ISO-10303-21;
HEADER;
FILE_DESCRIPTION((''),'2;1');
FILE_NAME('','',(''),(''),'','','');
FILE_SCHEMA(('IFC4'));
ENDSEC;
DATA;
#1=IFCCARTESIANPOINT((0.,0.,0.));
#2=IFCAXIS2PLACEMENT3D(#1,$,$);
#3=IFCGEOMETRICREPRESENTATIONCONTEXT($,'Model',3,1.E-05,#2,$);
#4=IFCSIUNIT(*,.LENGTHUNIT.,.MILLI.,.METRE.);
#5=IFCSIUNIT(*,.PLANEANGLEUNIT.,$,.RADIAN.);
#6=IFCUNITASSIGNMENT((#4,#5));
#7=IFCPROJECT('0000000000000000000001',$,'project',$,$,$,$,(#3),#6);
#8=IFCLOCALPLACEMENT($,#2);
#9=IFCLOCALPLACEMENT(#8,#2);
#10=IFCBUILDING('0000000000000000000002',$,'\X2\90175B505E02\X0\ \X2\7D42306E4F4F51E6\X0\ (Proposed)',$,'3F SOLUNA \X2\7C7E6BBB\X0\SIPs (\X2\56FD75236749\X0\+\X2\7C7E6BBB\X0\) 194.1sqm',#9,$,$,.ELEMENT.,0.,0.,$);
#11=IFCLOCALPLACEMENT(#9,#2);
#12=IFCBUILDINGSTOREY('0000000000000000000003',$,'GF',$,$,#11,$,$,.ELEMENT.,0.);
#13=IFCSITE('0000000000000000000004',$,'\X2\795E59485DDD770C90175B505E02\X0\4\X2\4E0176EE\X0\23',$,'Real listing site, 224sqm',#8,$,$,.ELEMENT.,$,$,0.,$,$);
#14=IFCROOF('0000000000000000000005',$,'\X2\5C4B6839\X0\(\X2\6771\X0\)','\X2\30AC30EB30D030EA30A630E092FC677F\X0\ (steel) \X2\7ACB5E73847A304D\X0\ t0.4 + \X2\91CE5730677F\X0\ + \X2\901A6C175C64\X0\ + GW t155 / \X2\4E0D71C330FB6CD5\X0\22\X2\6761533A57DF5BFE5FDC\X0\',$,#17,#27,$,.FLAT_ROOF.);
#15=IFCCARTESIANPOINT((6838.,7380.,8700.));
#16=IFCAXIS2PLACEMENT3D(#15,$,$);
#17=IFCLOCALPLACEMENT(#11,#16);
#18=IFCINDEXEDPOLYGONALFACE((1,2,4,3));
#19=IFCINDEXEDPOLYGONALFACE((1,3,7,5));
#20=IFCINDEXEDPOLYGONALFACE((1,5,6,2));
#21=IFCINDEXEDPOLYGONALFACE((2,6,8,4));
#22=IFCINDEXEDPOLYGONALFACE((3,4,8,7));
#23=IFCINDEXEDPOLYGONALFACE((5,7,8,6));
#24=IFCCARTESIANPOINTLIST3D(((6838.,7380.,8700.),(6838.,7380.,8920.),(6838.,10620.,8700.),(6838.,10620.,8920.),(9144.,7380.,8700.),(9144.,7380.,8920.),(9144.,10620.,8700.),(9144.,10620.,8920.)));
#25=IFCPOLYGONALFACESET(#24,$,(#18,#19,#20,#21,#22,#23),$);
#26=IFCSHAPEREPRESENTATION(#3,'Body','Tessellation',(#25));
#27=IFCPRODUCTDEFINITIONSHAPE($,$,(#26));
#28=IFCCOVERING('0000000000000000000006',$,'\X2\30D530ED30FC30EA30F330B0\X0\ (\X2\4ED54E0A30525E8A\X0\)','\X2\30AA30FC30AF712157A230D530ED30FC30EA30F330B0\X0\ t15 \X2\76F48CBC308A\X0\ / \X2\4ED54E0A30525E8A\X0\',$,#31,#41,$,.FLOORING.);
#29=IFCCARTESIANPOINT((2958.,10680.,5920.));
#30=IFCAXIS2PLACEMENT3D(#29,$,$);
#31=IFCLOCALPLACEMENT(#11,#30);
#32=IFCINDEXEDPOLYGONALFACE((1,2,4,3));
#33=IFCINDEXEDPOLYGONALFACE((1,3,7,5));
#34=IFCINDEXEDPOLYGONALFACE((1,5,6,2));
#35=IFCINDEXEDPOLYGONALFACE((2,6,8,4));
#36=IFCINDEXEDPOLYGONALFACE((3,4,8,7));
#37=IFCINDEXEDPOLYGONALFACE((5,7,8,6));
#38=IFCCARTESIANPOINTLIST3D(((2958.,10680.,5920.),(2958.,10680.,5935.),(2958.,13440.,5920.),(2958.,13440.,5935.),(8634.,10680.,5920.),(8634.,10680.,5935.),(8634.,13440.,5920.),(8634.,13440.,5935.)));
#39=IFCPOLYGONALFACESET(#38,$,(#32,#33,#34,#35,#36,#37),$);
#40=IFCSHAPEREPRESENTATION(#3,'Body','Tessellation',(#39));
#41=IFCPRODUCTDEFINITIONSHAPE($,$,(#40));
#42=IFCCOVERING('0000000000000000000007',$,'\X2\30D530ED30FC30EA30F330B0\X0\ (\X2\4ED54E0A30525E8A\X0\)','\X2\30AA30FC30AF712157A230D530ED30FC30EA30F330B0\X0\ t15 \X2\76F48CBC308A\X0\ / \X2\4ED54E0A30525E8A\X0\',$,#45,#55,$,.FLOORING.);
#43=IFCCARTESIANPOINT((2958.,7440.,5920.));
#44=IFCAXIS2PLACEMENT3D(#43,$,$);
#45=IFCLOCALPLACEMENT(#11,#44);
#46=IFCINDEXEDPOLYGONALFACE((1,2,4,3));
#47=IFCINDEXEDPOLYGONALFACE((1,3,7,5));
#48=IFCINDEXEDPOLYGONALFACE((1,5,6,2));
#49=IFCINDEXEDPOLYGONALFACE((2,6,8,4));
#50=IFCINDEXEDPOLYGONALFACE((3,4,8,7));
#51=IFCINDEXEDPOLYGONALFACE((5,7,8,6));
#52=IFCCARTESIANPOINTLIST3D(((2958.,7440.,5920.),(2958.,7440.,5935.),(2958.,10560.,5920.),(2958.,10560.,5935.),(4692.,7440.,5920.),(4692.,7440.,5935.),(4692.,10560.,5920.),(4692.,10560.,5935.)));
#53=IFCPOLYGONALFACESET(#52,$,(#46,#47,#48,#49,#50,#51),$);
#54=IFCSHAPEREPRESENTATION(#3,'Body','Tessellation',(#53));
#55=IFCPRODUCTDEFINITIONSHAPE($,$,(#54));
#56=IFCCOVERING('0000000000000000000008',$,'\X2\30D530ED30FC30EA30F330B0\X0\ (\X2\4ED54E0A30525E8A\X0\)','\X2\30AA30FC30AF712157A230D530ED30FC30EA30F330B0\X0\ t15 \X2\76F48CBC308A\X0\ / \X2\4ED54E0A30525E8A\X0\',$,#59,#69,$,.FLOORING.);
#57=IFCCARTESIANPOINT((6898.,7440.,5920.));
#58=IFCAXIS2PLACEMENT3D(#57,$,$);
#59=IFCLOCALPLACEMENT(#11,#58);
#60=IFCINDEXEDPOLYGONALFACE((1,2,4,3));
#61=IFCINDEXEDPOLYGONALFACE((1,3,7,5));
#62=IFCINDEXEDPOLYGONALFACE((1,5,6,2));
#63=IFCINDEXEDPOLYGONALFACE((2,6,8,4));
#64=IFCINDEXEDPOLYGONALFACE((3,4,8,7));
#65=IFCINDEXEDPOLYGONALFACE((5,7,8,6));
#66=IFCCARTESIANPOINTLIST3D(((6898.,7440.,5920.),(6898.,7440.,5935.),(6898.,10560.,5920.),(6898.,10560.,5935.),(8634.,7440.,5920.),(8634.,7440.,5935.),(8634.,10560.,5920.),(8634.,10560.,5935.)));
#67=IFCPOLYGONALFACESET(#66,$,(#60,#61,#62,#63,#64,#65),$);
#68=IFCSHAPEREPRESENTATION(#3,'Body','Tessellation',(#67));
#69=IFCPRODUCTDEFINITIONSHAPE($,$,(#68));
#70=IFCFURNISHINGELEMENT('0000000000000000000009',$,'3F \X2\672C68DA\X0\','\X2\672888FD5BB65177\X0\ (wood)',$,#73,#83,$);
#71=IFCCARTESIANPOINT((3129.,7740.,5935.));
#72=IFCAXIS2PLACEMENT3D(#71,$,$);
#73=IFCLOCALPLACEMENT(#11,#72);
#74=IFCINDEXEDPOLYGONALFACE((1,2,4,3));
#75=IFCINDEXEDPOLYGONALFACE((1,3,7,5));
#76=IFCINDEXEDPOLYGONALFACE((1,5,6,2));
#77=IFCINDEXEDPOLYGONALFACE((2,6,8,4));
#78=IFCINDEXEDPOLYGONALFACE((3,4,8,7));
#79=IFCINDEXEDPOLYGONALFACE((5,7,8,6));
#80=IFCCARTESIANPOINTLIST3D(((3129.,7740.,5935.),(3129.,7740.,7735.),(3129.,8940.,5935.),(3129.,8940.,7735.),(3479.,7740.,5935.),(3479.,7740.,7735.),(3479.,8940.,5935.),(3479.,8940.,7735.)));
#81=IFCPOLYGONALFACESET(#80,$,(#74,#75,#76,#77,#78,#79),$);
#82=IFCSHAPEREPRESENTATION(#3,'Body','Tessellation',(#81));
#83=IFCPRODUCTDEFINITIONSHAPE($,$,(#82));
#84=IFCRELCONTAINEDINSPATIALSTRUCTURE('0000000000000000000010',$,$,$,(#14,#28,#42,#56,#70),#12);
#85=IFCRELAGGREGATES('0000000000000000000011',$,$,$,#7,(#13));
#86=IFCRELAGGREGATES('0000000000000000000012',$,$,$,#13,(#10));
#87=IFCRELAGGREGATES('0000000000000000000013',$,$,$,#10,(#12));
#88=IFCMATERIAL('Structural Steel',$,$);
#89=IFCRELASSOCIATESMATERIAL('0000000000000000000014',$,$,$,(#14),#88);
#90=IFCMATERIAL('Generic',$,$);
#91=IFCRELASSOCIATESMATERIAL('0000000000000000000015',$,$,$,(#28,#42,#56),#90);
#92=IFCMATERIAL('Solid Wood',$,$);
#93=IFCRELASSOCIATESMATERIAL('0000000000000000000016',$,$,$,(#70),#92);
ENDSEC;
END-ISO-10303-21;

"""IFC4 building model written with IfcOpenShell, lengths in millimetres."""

from ifc_helpers import new_model, si_unit, frame, frame_2d, origin, place, context, project, spatial, rectangle, extrude, material, element, save


model = new_model("IFC4")

# Units and contexts
model_context = context("Model", 3, precision=1e-05, world=origin())
ifc_project = project(units=[si_unit("LENGTHUNIT", "METRE", prefix="MILLI"), si_unit("PLANEANGLEUNIT", "RADIAN")], contexts=[model_context])

# Site, building, storey
site_placement = place(None, origin())
site = spatial("IfcSite", under=ifc_project, at=site_placement, Name="神奈川県逗子市4丁目23", ObjectType="Real listing site, 224sqm", CompositionType="ELEMENT", RefElevation=0.0)
building_placement = place(site_placement, origin())
building = spatial("IfcBuilding", under=site, at=building_placement, Name="逗子市 終の住処 (Proposed)", ObjectType="3F SOLUNA 籾殻SIPs (国産杉+籾殻) 194.1sqm", CompositionType="ELEMENT", ElevationOfRefHeight=0.0, ElevationOfTerrain=0.0)
storey_placement = place(building_placement, origin())
storey = spatial("IfcBuildingStorey", under=building, at=storey_placement, Name="GF", CompositionType="ELEMENT", Elevation=0.0)

# Shared definitions
ifc_material_1 = material(Name="Solid Wood")

# Shared definitions
ifc_material_2 = material(Name="Generic")

# Roof
ifc_material_3 = material(Name="Structural Steel")
roof_1_placement = place(storey_placement, frame((6838.0, 7380.0, 8700.0)))
element("IfcRoof", 1, at=roof_1_placement, inside=storey, material=ifc_material_3, Name="屋根(東)", Description="ガルバリウム鋼板 (steel) 立平葺き t0.4 + 野地板 + 通気層 + GW t155 / 不燃・法22条区域対応", PredefinedType="FLAT_ROOF", context=model_context, shape_type="SweptSolid", body=[
    extrude(rectangle(XDim=2306.0, YDim=3240.0, at=frame_2d((1153.0, 1620.0))), frame((6838.0, 7380.0, 8700.0)), (0.0, 0.0, 1.0), 220.0),
])

# Coverings
covering_1_placement = place(storey_placement, frame((2958.0, 10680.0, 5920.0)))
element("IfcCovering", 2, at=covering_1_placement, inside=storey, material=ifc_material_2, Name="フローリング (仕上げ床)", Description="オーク無垢フローリング t15 直貼り / 仕上げ床", PredefinedType="FLOORING", context=model_context, shape_type="SweptSolid", body=[
    extrude(rectangle(XDim=5676.0, YDim=2760.0, at=frame_2d((2838.0, 1380.0))), frame((2958.0, 10680.0, 5920.0)), (0.0, 0.0, 1.0), 15.0),
])
covering_2_placement = place(storey_placement, frame((2958.0, 7440.0, 5920.0)))
element("IfcCovering", 3, at=covering_2_placement, inside=storey, material=ifc_material_2, Name="フローリング (仕上げ床)", Description="オーク無垢フローリング t15 直貼り / 仕上げ床", PredefinedType="FLOORING", context=model_context, shape_type="SweptSolid", body=[
    extrude(rectangle(XDim=1734.0, YDim=3120.0, at=frame_2d((867.0, 1560.0))), frame((2958.0, 7440.0, 5920.0)), (0.0, 0.0, 1.0), 15.0),
])
covering_3_placement = place(storey_placement, frame((6898.0, 7440.0, 5920.0)))
element("IfcCovering", 4, at=covering_3_placement, inside=storey, material=ifc_material_2, Name="フローリング (仕上げ床)", Description="オーク無垢フローリング t15 直貼り / 仕上げ床", PredefinedType="FLOORING", context=model_context, shape_type="SweptSolid", body=[
    extrude(rectangle(XDim=1736.0, YDim=3120.0, at=frame_2d((868.0, 1560.0))), frame((6898.0, 7440.0, 5920.0)), (0.0, 0.0, 1.0), 15.0),
])

# Furnishing element
furnishing_placement = place(storey_placement, frame((3129.0, 7740.0, 5935.0)))
element("IfcFurnishingElement", 5, at=furnishing_placement, inside=storey, material=ifc_material_1, Name="3F 本棚", Description="木製家具 (wood)", context=model_context, shape_type="SweptSolid", body=[
    extrude(rectangle(XDim=350.0, YDim=1200.0, at=frame_2d((175.0, 600.0))), frame((3129.0, 7740.0, 5935.0)), (0.0, 0.0, 1.0), 1800.0),
])

save(model, "model.ifc")
